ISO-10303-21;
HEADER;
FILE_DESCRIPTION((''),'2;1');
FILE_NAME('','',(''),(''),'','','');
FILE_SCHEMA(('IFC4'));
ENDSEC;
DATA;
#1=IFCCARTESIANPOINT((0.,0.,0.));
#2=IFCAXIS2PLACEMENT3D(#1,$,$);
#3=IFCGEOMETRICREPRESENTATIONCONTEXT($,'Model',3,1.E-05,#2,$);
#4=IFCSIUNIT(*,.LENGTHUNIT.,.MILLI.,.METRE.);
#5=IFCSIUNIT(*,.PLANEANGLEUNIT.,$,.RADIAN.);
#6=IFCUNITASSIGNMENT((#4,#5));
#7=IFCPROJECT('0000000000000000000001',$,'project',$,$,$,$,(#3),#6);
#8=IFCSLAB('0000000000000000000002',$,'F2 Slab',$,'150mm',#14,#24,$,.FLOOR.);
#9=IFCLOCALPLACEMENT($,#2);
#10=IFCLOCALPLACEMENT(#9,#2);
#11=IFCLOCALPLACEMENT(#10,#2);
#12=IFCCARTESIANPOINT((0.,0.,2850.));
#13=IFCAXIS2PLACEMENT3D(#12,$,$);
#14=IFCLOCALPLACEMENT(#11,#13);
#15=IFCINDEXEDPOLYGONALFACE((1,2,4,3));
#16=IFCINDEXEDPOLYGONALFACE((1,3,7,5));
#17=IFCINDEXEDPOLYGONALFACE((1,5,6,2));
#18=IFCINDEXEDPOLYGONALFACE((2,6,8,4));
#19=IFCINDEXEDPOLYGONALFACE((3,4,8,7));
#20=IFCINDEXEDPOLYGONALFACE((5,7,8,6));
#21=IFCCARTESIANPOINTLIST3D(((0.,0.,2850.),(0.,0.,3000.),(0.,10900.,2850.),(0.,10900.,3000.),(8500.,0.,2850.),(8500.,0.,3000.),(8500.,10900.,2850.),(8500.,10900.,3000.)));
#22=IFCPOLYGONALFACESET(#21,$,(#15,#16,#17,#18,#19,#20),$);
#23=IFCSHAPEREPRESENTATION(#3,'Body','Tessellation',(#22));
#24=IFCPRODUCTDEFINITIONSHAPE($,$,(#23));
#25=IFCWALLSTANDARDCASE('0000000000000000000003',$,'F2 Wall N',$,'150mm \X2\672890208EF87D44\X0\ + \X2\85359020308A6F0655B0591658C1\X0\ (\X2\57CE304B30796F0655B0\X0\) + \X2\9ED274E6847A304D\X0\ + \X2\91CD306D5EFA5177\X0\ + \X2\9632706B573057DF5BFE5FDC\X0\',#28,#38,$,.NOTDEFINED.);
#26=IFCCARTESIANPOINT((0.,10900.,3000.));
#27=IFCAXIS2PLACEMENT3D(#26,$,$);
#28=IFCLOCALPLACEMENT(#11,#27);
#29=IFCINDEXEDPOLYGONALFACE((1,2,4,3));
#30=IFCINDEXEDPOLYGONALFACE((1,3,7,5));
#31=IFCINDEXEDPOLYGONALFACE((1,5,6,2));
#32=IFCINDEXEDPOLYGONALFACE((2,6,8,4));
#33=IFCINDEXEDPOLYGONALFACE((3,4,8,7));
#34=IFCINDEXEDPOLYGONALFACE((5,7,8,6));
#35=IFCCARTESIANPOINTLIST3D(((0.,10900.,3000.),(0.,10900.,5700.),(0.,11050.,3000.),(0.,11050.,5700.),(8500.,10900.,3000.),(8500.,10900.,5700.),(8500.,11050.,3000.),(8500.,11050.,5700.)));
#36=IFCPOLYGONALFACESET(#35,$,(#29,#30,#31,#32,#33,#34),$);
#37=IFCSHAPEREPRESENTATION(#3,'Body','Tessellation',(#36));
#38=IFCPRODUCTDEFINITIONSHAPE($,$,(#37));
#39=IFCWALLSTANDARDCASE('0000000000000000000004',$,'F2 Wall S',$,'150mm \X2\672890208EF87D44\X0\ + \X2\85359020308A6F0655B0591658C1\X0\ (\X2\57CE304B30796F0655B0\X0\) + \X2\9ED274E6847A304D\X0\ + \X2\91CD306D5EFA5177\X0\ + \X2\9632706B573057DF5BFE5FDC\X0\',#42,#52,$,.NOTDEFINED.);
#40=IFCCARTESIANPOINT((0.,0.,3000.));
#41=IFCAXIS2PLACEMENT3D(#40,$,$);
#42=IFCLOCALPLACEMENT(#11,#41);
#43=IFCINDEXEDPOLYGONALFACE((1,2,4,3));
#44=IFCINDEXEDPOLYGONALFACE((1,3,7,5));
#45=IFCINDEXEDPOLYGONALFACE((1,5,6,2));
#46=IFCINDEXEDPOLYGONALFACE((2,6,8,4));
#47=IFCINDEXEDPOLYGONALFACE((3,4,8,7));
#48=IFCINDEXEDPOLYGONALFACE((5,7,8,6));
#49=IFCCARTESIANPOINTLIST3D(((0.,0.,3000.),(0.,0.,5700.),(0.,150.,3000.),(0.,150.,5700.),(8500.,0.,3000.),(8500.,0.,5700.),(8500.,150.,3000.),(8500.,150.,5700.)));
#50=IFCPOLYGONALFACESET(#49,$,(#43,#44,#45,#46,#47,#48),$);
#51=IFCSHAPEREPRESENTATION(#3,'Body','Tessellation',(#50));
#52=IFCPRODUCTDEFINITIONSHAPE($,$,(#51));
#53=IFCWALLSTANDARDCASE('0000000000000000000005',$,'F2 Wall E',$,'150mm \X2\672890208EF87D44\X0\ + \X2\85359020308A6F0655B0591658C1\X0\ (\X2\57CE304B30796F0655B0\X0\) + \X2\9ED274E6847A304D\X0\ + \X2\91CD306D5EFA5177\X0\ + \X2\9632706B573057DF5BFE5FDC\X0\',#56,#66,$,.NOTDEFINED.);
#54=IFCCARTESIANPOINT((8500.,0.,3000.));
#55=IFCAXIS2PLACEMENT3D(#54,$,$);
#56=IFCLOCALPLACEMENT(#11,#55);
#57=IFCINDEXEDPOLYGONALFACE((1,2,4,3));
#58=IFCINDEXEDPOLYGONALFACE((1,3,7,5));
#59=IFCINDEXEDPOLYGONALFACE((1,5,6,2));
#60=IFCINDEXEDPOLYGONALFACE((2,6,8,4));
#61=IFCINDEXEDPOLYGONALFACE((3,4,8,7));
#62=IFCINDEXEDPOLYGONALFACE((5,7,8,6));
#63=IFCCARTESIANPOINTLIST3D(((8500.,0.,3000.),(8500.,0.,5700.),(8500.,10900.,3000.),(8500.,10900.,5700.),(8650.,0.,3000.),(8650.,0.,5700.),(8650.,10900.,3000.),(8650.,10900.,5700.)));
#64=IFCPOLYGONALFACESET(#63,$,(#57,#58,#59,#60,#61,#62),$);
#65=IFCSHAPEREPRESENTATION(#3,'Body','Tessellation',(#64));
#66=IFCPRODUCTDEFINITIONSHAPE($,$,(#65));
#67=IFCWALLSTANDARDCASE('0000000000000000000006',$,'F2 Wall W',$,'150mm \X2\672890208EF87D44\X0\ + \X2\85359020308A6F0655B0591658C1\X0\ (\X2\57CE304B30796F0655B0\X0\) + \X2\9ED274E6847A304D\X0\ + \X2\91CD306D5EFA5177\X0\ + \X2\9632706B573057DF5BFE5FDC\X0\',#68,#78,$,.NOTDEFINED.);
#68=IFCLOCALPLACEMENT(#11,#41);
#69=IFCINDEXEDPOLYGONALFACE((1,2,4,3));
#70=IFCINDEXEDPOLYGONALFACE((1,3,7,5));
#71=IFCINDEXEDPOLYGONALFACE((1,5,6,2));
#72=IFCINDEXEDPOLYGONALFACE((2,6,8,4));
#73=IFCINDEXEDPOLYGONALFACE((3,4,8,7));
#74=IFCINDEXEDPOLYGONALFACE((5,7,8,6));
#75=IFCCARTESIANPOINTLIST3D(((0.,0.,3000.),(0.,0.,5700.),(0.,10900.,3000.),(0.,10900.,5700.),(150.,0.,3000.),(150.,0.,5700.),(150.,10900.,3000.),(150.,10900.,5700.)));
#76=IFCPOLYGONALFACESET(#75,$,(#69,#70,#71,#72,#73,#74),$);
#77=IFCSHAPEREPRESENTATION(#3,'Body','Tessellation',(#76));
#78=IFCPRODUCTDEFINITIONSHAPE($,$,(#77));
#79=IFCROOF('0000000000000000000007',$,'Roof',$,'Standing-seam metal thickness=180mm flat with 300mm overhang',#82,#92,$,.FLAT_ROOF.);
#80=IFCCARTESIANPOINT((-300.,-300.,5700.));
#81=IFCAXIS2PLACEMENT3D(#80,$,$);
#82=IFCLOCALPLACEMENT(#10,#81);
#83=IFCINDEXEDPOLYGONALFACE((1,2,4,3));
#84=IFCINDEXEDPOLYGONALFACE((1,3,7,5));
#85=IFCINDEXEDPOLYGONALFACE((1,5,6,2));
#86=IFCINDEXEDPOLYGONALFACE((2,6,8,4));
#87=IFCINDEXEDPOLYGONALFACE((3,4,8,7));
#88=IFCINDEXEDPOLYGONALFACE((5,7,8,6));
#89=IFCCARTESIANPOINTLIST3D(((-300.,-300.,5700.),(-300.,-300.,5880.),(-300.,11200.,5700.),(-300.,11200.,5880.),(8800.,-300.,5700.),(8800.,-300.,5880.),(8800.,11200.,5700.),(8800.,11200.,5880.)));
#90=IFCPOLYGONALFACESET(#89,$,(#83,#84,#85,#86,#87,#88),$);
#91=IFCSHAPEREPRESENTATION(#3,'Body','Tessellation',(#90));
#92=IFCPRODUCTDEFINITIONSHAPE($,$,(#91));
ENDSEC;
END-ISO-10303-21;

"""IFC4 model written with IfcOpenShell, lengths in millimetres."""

from ifc_helpers import new_model, si_unit, frame, frame_2d, origin, place, context, project, rectangle, extrude, element, save


model = new_model("IFC4")

# Units and contexts
model_context = context("Model", 3, precision=1e-05, world=origin())
ifc_project = project(units=[si_unit("LENGTHUNIT", "METRE", prefix="MILLI"), si_unit("PLANEANGLEUNIT", "RADIAN")], contexts=[model_context])

# Slab
placement_1 = place(None, origin())
placement_2 = place(placement_1, origin())
placement_3 = place(placement_2, origin())
slab_placement = place(placement_3, frame((0.0, 0.0, 2850.0)))
element("IfcSlab", 1, at=slab_placement, Name="F2 Slab", ObjectType="150mm", PredefinedType="FLOOR", context=model_context, shape_type="SweptSolid", body=[
    extrude(rectangle(XDim=8500.0, YDim=10900.0, at=frame_2d((4250.0, 5450.0))), frame((0.0, 0.0, 2850.0)), (0.0, 0.0, 1.0), 150.0),
])

# Walls
wall_1_placement = place(placement_3, frame((0.0, 10900.0, 3000.0)))
element("IfcWallStandardCase", 2, at=wall_1_placement, Name="F2 Wall N", ObjectType="150mm 木造軸組 + 蔵造り漆喰外壁 (城かべ漆喰) + 黒瓦葺き + 重ね建具 + 防火地域対応", PredefinedType="NOTDEFINED", context=model_context, shape_type="SweptSolid", body=[
    extrude(rectangle(XDim=8500.0, YDim=150.0, at=frame_2d((4250.0, 75.0))), frame((0.0, 10900.0, 3000.0)), (0.0, 0.0, 1.0), 2700.0),
])
wall_2_placement = place(placement_3, frame((0.0, 0.0, 3000.0)))
element("IfcWallStandardCase", 3, at=wall_2_placement, Name="F2 Wall S", ObjectType="150mm 木造軸組 + 蔵造り漆喰外壁 (城かべ漆喰) + 黒瓦葺き + 重ね建具 + 防火地域対応", PredefinedType="NOTDEFINED", context=model_context, shape_type="SweptSolid", body=[
    extrude(rectangle(XDim=8500.0, YDim=150.0, at=frame_2d((4250.0, 75.0))), frame((0.0, 0.0, 3000.0)), (0.0, 0.0, 1.0), 2700.0),
])
wall_3_placement = place(placement_3, frame((8500.0, 0.0, 3000.0)))
element("IfcWallStandardCase", 4, at=wall_3_placement, Name="F2 Wall E", ObjectType="150mm 木造軸組 + 蔵造り漆喰外壁 (城かべ漆喰) + 黒瓦葺き + 重ね建具 + 防火地域対応", PredefinedType="NOTDEFINED", context=model_context, shape_type="SweptSolid", body=[
    extrude(rectangle(XDim=150.0, YDim=10900.0, at=frame_2d((75.0, 5450.0))), frame((8500.0, 0.0, 3000.0)), (0.0, 0.0, 1.0), 2700.0),
])
wall_4_placement = place(placement_3, frame((0.0, 0.0, 3000.0)))
element("IfcWallStandardCase", 5, at=wall_4_placement, Name="F2 Wall W", ObjectType="150mm 木造軸組 + 蔵造り漆喰外壁 (城かべ漆喰) + 黒瓦葺き + 重ね建具 + 防火地域対応", PredefinedType="NOTDEFINED", context=model_context, shape_type="SweptSolid", body=[
    extrude(rectangle(XDim=150.0, YDim=10900.0, at=frame_2d((75.0, 5450.0))), frame((0.0, 0.0, 3000.0)), (0.0, 0.0, 1.0), 2700.0),
])

# Roof
roof_placement = place(placement_2, frame((-300.0, -300.0, 5700.0)))
element("IfcRoof", 6, at=roof_placement, Name="Roof", ObjectType="Standing-seam metal thickness=180mm flat with 300mm overhang", PredefinedType="FLAT_ROOF", context=model_context, shape_type="SweptSolid", body=[
    extrude(rectangle(XDim=9100.0, YDim=11500.0, at=frame_2d((4550.0, 5750.0))), frame((-300.0, -300.0, 5700.0)), (0.0, 0.0, 1.0), 180.0),
])

save(model, "model.ifc")
